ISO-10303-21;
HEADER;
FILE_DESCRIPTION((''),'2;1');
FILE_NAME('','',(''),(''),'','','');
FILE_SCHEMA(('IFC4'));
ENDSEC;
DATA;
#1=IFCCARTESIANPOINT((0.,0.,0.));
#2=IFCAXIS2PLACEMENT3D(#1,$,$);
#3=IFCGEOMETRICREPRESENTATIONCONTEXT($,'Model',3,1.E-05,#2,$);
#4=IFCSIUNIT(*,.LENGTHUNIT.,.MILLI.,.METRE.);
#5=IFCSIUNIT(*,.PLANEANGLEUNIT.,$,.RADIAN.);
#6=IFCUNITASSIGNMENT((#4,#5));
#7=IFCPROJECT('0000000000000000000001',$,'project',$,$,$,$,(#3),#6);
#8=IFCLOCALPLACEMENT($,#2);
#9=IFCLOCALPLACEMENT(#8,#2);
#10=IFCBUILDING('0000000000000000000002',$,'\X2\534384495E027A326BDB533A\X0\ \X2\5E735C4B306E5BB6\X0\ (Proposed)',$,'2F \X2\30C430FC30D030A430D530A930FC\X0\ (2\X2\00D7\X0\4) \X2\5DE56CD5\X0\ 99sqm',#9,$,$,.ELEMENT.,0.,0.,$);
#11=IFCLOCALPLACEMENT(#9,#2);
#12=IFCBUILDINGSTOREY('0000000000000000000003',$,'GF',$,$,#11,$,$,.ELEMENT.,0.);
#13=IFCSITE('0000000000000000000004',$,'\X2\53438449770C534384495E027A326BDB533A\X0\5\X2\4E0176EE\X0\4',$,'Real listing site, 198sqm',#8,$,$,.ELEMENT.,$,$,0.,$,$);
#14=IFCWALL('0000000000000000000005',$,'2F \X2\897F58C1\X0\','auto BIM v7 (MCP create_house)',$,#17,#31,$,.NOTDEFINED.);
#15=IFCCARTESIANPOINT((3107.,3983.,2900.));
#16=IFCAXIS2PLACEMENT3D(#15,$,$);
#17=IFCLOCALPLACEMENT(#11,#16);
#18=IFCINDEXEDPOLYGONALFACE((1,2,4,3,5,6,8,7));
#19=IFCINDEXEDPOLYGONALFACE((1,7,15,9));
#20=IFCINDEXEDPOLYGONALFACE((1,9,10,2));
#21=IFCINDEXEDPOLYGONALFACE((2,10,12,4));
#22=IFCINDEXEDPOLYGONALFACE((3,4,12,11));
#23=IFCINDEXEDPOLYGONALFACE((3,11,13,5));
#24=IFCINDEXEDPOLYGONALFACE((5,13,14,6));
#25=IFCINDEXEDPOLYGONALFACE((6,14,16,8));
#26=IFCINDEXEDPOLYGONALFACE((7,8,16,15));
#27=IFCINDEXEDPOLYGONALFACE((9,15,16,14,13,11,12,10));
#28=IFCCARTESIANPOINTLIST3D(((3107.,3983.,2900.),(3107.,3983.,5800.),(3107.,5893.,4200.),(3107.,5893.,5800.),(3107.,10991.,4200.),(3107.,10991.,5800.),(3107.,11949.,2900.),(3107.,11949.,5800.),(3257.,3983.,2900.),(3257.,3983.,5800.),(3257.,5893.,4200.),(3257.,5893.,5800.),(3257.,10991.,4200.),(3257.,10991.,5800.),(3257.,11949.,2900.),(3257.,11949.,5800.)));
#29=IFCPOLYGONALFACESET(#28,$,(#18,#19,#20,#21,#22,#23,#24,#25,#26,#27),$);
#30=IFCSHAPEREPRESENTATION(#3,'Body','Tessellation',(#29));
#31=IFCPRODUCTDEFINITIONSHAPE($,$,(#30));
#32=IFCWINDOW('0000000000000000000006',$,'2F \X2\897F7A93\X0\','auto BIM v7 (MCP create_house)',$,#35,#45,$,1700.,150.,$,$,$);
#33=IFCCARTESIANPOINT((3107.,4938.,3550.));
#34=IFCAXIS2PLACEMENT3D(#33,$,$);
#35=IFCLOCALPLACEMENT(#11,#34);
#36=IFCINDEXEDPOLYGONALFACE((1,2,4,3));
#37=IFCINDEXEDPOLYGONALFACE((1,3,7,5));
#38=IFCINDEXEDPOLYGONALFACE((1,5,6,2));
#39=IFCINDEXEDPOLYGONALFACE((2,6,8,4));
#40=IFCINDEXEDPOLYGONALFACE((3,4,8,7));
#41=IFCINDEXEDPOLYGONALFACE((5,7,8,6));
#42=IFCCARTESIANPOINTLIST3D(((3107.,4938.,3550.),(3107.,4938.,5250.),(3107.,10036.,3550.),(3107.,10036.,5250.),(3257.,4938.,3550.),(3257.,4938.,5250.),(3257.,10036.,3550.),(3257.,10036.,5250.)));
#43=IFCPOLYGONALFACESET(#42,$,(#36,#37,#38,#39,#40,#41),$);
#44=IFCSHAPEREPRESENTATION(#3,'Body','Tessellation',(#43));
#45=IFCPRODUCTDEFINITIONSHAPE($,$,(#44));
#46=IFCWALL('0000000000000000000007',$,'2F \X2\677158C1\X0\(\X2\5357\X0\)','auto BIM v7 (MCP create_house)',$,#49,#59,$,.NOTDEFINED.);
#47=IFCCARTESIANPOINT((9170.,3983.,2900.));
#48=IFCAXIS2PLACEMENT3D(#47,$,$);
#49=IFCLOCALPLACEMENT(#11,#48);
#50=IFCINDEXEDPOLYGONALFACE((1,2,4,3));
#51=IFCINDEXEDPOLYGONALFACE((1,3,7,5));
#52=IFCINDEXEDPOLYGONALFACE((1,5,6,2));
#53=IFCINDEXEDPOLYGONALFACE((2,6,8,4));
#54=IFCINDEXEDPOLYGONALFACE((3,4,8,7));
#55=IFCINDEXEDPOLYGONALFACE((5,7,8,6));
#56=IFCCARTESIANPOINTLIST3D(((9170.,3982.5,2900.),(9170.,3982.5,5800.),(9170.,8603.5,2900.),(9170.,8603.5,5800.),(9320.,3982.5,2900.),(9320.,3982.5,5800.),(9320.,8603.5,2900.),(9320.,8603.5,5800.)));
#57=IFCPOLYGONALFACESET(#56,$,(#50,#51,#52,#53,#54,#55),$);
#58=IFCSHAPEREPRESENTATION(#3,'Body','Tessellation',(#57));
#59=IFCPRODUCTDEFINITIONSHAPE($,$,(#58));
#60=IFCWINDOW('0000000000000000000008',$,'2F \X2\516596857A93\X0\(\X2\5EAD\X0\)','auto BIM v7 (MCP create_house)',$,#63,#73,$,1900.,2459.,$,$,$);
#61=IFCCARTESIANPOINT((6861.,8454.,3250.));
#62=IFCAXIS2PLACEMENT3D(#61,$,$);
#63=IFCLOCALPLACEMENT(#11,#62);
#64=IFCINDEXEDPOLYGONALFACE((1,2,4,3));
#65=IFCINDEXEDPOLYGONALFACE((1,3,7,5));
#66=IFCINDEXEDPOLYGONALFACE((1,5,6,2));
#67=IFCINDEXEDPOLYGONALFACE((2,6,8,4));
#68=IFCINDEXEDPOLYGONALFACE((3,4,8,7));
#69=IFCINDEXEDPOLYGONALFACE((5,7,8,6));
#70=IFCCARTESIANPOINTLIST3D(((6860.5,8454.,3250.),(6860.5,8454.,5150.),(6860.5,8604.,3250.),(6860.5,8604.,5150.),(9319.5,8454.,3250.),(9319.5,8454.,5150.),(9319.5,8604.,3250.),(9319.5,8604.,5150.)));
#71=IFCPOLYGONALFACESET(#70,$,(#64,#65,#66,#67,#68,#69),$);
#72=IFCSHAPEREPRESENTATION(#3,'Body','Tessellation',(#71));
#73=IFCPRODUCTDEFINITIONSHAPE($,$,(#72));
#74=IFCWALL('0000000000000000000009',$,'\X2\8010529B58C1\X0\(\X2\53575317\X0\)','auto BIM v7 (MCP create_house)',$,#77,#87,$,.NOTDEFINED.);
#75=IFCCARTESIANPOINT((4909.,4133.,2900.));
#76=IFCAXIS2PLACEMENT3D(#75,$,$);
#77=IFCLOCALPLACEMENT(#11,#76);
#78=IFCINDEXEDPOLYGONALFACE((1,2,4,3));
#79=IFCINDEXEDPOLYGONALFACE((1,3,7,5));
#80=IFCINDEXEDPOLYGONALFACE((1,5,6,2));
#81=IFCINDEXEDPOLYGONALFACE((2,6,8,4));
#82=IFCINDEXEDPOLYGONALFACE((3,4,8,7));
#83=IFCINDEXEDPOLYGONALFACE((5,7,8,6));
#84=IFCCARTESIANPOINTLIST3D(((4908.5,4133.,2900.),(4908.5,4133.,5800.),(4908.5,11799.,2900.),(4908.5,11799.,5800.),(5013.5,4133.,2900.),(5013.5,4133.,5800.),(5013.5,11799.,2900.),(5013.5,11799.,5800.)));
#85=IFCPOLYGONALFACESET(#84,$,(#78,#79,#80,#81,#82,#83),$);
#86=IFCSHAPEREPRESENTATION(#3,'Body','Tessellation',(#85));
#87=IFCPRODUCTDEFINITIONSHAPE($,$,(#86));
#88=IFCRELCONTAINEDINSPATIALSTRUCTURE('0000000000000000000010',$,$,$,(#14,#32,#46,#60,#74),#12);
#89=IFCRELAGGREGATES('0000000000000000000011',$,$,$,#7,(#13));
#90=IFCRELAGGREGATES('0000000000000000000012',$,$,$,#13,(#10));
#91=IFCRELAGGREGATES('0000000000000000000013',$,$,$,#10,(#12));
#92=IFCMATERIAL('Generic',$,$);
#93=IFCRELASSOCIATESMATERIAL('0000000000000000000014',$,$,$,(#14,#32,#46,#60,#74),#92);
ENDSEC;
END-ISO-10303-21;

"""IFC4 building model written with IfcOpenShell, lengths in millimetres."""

from ifc_helpers import new_model, si_unit, frame, frame_2d, origin, place, context, project, spatial, rectangle, extrude, material, element, fill, save


model = new_model("IFC4")

# Units and contexts
model_context = context("Model", 3, precision=1e-05, world=origin())
ifc_project = project(units=[si_unit("LENGTHUNIT", "METRE", prefix="MILLI"), si_unit("PLANEANGLEUNIT", "RADIAN")], contexts=[model_context])

# Site, building, storey
site_placement = place(None, origin())
site = spatial("IfcSite", under=ifc_project, at=site_placement, Name="千葉県千葉市稲毛区5丁目4", ObjectType="Real listing site, 198sqm", CompositionType="ELEMENT", RefElevation=0.0)
building_placement = place(site_placement, origin())
building = spatial("IfcBuilding", under=site, at=building_placement, Name="千葉市稲毛区 平屋の家 (Proposed)", ObjectType="2F ツーバイフォー (2×4) 工法 99sqm", CompositionType="ELEMENT", ElevationOfRefHeight=0.0, ElevationOfTerrain=0.0)
storey_placement = place(building_placement, origin())
storey = spatial("IfcBuildingStorey", under=building, at=storey_placement, Name="GF", CompositionType="ELEMENT", Elevation=0.0)

# Shared definitions
ifc_material = material(Name="Generic")

# Walls, openings, windows
wall_1_placement = place(storey_placement, frame((3107.0, 3983.0, 2900.0)))
wall_1 = element("IfcWall", 1, at=wall_1_placement, inside=storey, material=ifc_material, Name="2F 西壁", Description="auto BIM v7 (MCP create_house)", PredefinedType="NOTDEFINED", context=model_context, shape_type="SweptSolid", body=[
    extrude(rectangle(XDim=150.0, YDim=7966.0, at=frame_2d((75.0, 3983.0))), frame((3107.0, 3983.0, 2900.0)), (0.0, 0.0, 1.0), 2900.0),
])
opening_1_placement = place(storey_placement, frame((3107.0, 4938.0, 3550.0)))
opening_1 = element("IfcOpeningElement", 2, at=opening_1_placement, cuts=wall_1, PredefinedType="NOTDEFINED", context=model_context, shape_type="SweptSolid", body=[
    extrude(rectangle(XDim=150.0, YDim=5098.0, at=frame_2d((75.0, 2549.0))), frame((3107.0, 4938.0, 3550.0)), (0.0, 0.0, 1.0), 1700.0),
])
window_1_placement = place(storey_placement, frame((3107.0, 4938.0, 3550.0)))
window_1 = element("IfcWindow", 3, at=window_1_placement, inside=storey, material=ifc_material, Name="2F 西窓", Description="auto BIM v7 (MCP create_house)", OverallHeight=1700.0, OverallWidth=150.0, context=model_context, shape_type="SweptSolid", body=[
    extrude(rectangle(XDim=150.0, YDim=5098.0, at=frame_2d((75.0, 2549.0))), frame((3107.0, 4938.0, 3550.0)), (0.0, 0.0, 1.0), 1700.0),
])
fill(opening_1, window_1)
wall_2_placement = place(storey_placement, frame((9170.0, 3983.0, 2900.0)))
wall_2 = element("IfcWall", 4, at=wall_2_placement, inside=storey, material=ifc_material, Name="2F 東壁(南)", Description="auto BIM v7 (MCP create_house)", PredefinedType="NOTDEFINED", context=model_context, shape_type="SweptSolid", body=[
    extrude(rectangle(XDim=150.0, YDim=4621.0, at=frame_2d((75.0, 2310.0))), frame((9170.0, 3983.0, 2900.0)), (0.0, 0.0, 1.0), 2900.0),
])
opening_2_placement = place(storey_placement, frame((6861.0, 8454.0, 3250.0)))
opening_2 = element("IfcOpeningElement", 5, at=opening_2_placement, cuts=wall_2, PredefinedType="NOTDEFINED", context=model_context, shape_type="SweptSolid", body=[
    extrude(rectangle(XDim=2459.0, YDim=150.0, at=frame_2d((1229.0, 75.0))), frame((6861.0, 8454.0, 3250.0)), (0.0, 0.0, 1.0), 1900.0),
])
window_2_placement = place(storey_placement, frame((6861.0, 8454.0, 3250.0)))
window_2 = element("IfcWindow", 6, at=window_2_placement, inside=storey, material=ifc_material, Name="2F 入隅窓(庭)", Description="auto BIM v7 (MCP create_house)", OverallHeight=1900.0, OverallWidth=2459.0, context=model_context, shape_type="SweptSolid", body=[
    extrude(rectangle(XDim=2459.0, YDim=150.0, at=frame_2d((1229.0, 75.0))), frame((6861.0, 8454.0, 3250.0)), (0.0, 0.0, 1.0), 1900.0),
])
fill(opening_2, window_2)

# Wall
wall_3_placement = place(storey_placement, frame((4909.0, 4133.0, 2900.0)))
element("IfcWall", 7, at=wall_3_placement, inside=storey, material=ifc_material, Name="耐力壁(南北)", Description="auto BIM v7 (MCP create_house)", PredefinedType="NOTDEFINED", context=model_context, shape_type="SweptSolid", body=[
    extrude(rectangle(XDim=105.0, YDim=7666.0, at=frame_2d((52.0, 3833.0))), frame((4909.0, 4133.0, 2900.0)), (0.0, 0.0, 1.0), 2900.0),
])

save(model, "model.ifc")
